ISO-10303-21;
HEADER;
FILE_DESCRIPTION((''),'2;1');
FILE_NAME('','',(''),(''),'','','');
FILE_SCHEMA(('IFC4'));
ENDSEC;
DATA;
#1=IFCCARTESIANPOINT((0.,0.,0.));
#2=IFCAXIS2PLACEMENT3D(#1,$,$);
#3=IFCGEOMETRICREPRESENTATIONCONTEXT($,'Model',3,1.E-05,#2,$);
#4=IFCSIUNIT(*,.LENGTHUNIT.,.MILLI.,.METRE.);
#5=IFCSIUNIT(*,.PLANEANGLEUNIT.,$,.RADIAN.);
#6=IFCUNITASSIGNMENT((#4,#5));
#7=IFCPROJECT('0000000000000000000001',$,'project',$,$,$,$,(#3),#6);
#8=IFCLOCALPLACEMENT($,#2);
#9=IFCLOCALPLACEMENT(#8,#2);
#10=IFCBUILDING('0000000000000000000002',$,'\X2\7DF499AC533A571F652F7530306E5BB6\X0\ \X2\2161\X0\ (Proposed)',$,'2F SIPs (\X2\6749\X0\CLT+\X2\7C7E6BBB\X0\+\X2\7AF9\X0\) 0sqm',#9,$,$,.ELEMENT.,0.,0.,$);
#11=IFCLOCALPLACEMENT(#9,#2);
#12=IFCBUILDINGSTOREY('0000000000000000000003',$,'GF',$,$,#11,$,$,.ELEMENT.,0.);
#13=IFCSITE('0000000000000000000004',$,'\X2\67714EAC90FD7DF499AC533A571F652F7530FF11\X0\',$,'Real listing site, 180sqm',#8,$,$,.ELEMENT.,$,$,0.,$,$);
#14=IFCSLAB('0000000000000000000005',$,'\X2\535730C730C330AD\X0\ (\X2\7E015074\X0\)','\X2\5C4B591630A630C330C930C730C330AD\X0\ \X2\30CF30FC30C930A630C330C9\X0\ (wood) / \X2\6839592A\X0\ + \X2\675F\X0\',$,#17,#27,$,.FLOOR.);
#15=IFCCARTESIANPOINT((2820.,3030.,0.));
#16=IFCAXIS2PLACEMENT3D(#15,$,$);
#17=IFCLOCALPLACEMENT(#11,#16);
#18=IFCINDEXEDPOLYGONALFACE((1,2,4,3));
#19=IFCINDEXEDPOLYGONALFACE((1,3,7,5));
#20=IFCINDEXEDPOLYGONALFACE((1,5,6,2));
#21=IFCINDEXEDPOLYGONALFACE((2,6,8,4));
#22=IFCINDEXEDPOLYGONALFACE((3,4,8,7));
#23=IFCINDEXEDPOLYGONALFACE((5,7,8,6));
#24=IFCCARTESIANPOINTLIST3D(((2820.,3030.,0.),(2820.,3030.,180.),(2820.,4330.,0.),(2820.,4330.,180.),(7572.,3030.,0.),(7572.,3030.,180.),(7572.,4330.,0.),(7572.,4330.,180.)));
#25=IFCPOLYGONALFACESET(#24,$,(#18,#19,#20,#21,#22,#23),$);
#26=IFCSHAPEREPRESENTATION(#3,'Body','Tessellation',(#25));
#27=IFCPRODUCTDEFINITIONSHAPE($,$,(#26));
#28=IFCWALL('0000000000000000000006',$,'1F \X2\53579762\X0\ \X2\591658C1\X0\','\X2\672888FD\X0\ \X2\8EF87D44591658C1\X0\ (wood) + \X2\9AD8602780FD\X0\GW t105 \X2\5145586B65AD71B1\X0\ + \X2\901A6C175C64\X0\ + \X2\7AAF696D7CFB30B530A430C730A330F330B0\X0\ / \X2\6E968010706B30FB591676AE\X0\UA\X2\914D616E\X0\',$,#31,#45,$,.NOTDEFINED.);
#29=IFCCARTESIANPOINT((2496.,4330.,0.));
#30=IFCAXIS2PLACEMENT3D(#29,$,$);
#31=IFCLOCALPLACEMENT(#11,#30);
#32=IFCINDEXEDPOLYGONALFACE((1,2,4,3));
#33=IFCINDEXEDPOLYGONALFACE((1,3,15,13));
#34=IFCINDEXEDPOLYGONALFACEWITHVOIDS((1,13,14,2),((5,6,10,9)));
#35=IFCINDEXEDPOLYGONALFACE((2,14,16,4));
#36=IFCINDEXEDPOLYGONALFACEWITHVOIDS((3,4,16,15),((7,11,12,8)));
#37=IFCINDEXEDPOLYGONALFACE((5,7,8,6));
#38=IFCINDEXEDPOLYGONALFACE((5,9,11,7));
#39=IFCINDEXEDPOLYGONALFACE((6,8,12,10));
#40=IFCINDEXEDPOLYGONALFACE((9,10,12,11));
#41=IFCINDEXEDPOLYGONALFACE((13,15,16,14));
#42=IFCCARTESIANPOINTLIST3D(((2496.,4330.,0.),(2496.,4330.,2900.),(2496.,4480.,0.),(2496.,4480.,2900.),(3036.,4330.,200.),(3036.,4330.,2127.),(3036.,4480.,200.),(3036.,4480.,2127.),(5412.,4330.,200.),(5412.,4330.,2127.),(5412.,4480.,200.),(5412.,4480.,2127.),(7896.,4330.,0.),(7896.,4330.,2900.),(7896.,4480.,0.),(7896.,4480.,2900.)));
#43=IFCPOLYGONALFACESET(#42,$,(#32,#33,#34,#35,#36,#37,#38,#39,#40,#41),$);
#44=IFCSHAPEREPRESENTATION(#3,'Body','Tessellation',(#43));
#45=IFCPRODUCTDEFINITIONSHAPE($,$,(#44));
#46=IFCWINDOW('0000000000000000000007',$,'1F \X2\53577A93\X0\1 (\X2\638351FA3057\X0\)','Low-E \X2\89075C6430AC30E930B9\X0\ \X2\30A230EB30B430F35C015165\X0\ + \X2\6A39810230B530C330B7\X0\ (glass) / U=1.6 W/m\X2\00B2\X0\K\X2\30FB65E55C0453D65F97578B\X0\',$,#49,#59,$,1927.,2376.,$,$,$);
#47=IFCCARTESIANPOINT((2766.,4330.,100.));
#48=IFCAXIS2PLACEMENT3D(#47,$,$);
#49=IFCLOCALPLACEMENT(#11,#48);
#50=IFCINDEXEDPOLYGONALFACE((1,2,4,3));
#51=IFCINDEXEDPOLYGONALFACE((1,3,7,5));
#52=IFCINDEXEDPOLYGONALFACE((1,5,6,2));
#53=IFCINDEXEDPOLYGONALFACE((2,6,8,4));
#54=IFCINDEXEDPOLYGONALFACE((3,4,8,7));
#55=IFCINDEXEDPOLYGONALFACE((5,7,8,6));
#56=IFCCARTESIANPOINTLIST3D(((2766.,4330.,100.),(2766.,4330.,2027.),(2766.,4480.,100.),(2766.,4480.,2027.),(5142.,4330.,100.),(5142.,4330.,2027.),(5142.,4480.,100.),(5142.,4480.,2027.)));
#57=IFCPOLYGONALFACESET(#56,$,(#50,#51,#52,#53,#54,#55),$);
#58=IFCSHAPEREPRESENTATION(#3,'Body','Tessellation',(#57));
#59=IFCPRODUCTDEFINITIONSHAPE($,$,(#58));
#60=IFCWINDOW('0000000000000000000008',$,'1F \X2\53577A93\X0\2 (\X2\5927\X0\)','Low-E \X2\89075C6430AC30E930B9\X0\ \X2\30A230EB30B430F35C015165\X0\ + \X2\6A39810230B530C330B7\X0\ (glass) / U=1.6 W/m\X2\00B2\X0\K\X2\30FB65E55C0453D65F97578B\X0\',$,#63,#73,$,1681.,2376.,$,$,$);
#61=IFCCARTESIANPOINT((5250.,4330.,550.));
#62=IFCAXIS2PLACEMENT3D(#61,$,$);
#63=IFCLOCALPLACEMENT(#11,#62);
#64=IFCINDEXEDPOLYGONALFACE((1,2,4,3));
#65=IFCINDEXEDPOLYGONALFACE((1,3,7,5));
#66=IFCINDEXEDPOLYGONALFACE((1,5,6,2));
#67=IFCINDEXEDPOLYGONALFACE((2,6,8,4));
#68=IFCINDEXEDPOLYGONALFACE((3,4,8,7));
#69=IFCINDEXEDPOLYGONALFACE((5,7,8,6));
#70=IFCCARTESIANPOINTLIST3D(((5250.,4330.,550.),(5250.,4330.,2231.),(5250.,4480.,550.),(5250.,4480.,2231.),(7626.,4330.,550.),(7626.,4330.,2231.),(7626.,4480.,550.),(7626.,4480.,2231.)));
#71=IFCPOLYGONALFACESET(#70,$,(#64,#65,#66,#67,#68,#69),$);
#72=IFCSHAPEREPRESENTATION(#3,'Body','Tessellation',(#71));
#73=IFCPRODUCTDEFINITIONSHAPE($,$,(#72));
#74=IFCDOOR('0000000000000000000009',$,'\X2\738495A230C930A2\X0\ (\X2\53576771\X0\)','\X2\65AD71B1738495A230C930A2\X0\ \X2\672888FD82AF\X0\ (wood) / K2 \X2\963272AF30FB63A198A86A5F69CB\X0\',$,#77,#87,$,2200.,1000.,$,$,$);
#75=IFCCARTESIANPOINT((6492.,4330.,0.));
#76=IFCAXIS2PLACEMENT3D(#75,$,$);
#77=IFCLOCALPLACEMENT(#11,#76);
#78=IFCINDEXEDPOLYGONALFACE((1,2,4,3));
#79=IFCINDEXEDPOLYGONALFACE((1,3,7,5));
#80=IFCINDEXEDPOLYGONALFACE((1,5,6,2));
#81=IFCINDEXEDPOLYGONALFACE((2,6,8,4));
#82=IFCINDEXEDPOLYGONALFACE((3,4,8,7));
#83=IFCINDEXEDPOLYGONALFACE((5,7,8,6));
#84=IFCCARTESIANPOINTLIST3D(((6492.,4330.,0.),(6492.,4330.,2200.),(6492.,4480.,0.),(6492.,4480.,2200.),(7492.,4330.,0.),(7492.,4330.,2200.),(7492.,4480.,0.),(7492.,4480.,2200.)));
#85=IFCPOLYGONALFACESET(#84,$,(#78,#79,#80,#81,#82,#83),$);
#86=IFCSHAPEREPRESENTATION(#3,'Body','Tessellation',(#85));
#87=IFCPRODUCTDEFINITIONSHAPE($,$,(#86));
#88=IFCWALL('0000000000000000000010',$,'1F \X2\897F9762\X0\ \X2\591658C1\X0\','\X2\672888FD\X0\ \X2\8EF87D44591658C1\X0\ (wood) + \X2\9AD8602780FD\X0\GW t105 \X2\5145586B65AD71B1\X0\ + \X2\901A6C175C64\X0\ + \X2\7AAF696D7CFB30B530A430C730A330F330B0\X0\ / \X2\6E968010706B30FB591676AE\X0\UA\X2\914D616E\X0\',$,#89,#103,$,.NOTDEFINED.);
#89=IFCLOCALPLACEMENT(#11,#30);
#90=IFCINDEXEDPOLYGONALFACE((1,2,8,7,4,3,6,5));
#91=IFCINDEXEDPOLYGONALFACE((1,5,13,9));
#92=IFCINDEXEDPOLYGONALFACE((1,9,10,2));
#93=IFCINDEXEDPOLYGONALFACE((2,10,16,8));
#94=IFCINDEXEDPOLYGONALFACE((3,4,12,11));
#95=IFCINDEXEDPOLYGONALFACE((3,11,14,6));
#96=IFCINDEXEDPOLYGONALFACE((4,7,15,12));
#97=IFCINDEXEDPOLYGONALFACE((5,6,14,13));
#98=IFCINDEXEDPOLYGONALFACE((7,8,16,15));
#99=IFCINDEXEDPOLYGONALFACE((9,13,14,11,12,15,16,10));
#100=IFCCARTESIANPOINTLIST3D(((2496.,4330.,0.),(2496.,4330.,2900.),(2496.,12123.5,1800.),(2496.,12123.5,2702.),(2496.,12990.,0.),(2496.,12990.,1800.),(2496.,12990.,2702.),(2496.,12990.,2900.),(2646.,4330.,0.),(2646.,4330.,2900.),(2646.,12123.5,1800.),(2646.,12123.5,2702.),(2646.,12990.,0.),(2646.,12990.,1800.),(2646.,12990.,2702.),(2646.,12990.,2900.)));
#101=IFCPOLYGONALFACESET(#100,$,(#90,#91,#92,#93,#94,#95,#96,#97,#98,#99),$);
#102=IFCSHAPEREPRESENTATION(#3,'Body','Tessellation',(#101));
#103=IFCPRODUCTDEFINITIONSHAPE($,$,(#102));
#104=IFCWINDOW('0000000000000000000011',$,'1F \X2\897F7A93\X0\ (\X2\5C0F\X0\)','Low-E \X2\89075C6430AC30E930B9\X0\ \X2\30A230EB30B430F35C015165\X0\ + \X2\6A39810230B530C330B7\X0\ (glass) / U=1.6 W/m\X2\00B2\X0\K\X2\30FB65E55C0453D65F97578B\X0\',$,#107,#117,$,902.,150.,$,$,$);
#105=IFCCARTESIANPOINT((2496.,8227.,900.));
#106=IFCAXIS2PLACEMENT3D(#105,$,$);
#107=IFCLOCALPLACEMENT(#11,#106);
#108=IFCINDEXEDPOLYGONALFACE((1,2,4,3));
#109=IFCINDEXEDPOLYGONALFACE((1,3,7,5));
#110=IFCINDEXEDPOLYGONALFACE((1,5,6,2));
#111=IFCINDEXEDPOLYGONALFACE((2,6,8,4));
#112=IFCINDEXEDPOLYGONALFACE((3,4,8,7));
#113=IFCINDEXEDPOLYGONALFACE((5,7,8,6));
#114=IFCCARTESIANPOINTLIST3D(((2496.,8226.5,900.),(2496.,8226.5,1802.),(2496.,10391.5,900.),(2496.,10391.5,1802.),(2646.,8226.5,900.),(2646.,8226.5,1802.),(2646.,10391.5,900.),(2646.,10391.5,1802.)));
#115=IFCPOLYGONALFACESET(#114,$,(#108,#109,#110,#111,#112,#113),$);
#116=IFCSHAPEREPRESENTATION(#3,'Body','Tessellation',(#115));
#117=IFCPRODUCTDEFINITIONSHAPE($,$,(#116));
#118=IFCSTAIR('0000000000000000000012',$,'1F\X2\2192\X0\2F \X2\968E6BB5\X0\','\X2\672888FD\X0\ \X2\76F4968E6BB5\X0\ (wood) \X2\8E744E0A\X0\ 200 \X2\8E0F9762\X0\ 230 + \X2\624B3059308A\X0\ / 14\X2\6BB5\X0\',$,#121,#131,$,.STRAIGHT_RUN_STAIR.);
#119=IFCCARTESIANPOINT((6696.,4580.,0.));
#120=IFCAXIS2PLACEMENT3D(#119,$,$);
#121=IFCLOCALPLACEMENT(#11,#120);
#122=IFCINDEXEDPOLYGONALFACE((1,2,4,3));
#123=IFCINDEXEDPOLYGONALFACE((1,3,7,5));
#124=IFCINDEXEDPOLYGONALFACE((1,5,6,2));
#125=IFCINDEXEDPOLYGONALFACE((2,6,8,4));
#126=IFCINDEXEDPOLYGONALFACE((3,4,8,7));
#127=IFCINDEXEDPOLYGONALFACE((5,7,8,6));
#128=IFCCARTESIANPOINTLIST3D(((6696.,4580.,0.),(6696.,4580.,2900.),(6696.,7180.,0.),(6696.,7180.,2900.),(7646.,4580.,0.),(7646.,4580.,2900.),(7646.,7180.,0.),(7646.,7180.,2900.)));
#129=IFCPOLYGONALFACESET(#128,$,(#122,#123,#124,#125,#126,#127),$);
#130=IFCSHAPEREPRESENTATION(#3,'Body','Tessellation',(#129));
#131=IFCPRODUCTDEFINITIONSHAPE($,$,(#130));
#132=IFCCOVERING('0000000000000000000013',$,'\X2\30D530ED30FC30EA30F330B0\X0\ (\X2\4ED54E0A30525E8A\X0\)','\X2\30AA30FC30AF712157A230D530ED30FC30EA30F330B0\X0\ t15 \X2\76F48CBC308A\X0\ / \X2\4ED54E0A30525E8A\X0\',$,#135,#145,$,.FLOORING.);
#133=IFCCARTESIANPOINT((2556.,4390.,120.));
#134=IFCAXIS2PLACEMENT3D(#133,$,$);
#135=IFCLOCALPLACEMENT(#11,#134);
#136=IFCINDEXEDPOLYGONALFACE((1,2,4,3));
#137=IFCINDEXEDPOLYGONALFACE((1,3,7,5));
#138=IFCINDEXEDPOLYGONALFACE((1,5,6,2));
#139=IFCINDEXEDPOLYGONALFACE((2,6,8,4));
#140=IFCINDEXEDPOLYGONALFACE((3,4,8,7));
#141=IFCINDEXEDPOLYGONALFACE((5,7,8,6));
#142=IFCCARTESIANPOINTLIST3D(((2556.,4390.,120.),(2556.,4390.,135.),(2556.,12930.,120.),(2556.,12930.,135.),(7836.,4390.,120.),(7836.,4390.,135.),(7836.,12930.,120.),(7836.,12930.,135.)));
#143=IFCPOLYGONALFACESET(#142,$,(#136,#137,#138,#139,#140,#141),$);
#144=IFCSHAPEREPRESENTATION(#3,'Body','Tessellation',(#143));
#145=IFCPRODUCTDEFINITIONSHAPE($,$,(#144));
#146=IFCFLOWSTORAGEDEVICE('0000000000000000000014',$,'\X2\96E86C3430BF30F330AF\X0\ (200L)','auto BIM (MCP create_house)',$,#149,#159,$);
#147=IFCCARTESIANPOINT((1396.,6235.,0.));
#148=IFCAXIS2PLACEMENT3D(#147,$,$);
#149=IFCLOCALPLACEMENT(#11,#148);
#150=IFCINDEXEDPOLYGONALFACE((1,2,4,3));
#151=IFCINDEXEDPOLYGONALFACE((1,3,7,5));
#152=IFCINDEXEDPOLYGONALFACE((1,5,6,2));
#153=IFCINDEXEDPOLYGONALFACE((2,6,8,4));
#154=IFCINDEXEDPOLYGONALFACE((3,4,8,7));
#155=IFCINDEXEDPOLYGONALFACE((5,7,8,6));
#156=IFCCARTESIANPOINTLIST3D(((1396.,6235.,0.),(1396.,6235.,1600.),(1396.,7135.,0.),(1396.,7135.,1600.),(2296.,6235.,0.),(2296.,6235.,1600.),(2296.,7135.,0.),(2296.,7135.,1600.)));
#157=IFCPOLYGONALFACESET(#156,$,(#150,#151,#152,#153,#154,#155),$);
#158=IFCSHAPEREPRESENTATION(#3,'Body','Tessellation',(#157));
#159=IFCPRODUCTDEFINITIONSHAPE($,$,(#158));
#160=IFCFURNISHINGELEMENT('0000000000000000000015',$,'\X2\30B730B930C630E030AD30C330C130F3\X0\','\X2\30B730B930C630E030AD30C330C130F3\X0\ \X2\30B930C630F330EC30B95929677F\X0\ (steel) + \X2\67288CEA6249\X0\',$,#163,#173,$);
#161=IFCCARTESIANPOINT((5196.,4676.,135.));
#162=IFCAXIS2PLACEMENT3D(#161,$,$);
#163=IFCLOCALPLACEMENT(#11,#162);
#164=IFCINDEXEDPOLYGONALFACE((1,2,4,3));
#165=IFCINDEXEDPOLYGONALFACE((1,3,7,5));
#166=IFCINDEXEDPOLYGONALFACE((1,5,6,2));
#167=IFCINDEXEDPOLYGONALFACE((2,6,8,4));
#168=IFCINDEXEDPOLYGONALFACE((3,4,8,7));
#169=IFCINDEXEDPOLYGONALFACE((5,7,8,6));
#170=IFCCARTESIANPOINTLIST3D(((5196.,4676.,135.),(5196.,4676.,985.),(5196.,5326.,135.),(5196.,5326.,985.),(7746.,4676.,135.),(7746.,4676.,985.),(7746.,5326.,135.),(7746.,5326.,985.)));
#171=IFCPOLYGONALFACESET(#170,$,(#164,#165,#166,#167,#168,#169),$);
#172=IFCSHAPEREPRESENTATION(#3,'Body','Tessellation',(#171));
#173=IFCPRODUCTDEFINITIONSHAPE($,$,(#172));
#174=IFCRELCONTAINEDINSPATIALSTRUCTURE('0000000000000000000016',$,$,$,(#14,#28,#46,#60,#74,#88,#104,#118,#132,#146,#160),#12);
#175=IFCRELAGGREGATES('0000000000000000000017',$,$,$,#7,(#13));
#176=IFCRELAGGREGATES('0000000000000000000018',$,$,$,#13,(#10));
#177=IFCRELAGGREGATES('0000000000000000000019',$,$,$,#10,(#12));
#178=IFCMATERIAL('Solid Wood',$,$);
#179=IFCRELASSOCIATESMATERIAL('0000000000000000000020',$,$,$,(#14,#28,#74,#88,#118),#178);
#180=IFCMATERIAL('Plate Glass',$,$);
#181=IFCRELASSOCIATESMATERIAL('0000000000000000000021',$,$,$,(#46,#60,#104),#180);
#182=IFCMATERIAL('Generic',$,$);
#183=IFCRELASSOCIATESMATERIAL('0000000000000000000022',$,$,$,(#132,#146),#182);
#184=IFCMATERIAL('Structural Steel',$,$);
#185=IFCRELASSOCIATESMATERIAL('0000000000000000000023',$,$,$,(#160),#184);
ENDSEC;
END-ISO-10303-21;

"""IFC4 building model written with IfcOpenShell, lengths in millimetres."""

from ifc_helpers import new_model, si_unit, frame, frame_2d, origin, place, context, project, spatial, rectangle, extrude, material, element, fill, save


model = new_model("IFC4")

# Units and contexts
model_context = context("Model", 3, precision=1e-05, world=origin())
ifc_project = project(units=[si_unit("LENGTHUNIT", "METRE", prefix="MILLI"), si_unit("PLANEANGLEUNIT", "RADIAN")], contexts=[model_context])

# Site, building, storey
site_placement = place(None, origin())
site = spatial("IfcSite", under=ifc_project, at=site_placement, Name="東京都練馬区土支田１", ObjectType="Real listing site, 180sqm", CompositionType="ELEMENT", RefElevation=0.0)
building_placement = place(site_placement, origin())
building = spatial("IfcBuilding", under=site, at=building_placement, Name="練馬区土支田の家 Ⅱ (Proposed)", ObjectType="2F SIPs (杉CLT+籾殻+竹) 0sqm", CompositionType="ELEMENT", ElevationOfRefHeight=0.0, ElevationOfTerrain=0.0)
storey_placement = place(building_placement, origin())
storey = spatial("IfcBuildingStorey", under=building, at=storey_placement, Name="GF", CompositionType="ELEMENT", Elevation=0.0)

# Slab
ifc_material_1 = material(Name="Solid Wood")
slab_1_placement = place(storey_placement, frame((2820.0, 3030.0, 0.0)))
element("IfcSlab", 1, at=slab_1_placement, inside=storey, material=ifc_material_1, Name="南デッキ (縁側)", Description="屋外ウッドデッキ ハードウッド (wood) / 根太 + 束", PredefinedType="FLOOR", context=model_context, shape_type="SweptSolid", body=[
    extrude(rectangle(XDim=4752.0, YDim=1300.0, at=frame_2d((2376.0, 650.0))), frame((2820.0, 3030.0, 0.0)), (0.0, 0.0, 1.0), 180.0),
])

# Wall, openings, windows, door
wall_1_placement = place(storey_placement, frame((2496.0, 4330.0, 0.0)))
wall_1 = element("IfcWall", 2, at=wall_1_placement, inside=storey, material=ifc_material_1, Name="1F 南面 外壁", Description="木製 軸組外壁 (wood) + 高性能GW t105 充填断熱 + 通気層 + 窯業系サイディング / 準耐火・外皮UA配慮", PredefinedType="NOTDEFINED", context=model_context, shape_type="SweptSolid", body=[
    extrude(rectangle(XDim=5400.0, YDim=150.0, at=frame_2d((2700.0, 75.0))), frame((2496.0, 4330.0, 0.0)), (0.0, 0.0, 1.0), 2900.0),
])
opening_1_placement = place(storey_placement, frame((2766.0, 4330.0, 100.0)))
opening_1 = element("IfcOpeningElement", 3, at=opening_1_placement, cuts=wall_1, PredefinedType="NOTDEFINED", context=model_context, shape_type="SweptSolid", body=[
    extrude(rectangle(XDim=2376.0, YDim=150.0, at=frame_2d((1188.0, 75.0))), frame((2766.0, 4330.0, 100.0)), (0.0, 0.0, 1.0), 1927.0),
])
opening_2_placement = place(storey_placement, frame((5250.0, 4330.0, 550.0)))
opening_2 = element("IfcOpeningElement", 4, at=opening_2_placement, cuts=wall_1, PredefinedType="NOTDEFINED", context=model_context, shape_type="SweptSolid", body=[
    extrude(rectangle(XDim=2376.0, YDim=150.0, at=frame_2d((1188.0, 75.0))), frame((5250.0, 4330.0, 550.0)), (0.0, 0.0, 1.0), 1681.0),
])
opening_3_placement = place(storey_placement, frame((6492.0, 4330.0, 0.0)))
opening_3 = element("IfcOpeningElement", 5, at=opening_3_placement, cuts=wall_1, PredefinedType="NOTDEFINED", context=model_context, shape_type="SweptSolid", body=[
    extrude(rectangle(XDim=1000.0, YDim=150.0, at=frame_2d((500.0, 75.0))), frame((6492.0, 4330.0, 0.0)), (0.0, 0.0, 1.0), 2200.0),
])
ifc_material_2 = material(Name="Plate Glass")
window_1_placement = place(storey_placement, frame((2766.0, 4330.0, 100.0)))
window_1 = element("IfcWindow", 6, at=window_1_placement, inside=storey, material=ifc_material_2, Name="1F 南窓1 (掃出し)", Description="Low-E 複層ガラス アルゴン封入 + 樹脂サッシ (glass) / U=1.6 W/m²K・日射取得型", OverallHeight=1927.0, OverallWidth=2376.0, context=model_context, shape_type="SweptSolid", body=[
    extrude(rectangle(XDim=2376.0, YDim=150.0, at=frame_2d((1188.0, 75.0))), frame((2766.0, 4330.0, 100.0)), (0.0, 0.0, 1.0), 1927.0),
])
fill(opening_1, window_1)
window_2_placement = place(storey_placement, frame((5250.0, 4330.0, 550.0)))
window_2 = element("IfcWindow", 7, at=window_2_placement, inside=storey, material=ifc_material_2, Name="1F 南窓2 (大)", Description="Low-E 複層ガラス アルゴン封入 + 樹脂サッシ (glass) / U=1.6 W/m²K・日射取得型", OverallHeight=1681.0, OverallWidth=2376.0, context=model_context, shape_type="SweptSolid", body=[
    extrude(rectangle(XDim=2376.0, YDim=150.0, at=frame_2d((1188.0, 75.0))), frame((5250.0, 4330.0, 550.0)), (0.0, 0.0, 1.0), 1681.0),
])
fill(opening_2, window_2)
door_placement = place(storey_placement, frame((6492.0, 4330.0, 0.0)))
door = element("IfcDoor", 8, at=door_placement, inside=storey, material=ifc_material_1, Name="玄関ドア (南東)", Description="断熱玄関ドア 木製芯 (wood) / K2 防犯・採風機構", OverallHeight=2200.0, OverallWidth=1000.0, context=model_context, shape_type="SweptSolid", body=[
    extrude(rectangle(XDim=1000.0, YDim=150.0, at=frame_2d((500.0, 75.0))), frame((6492.0, 4330.0, 0.0)), (0.0, 0.0, 1.0), 2200.0),
])
fill(opening_3, door)

# Wall, opening, window
wall_2_placement = place(storey_placement, frame((2496.0, 4330.0, 0.0)))
wall_2 = element("IfcWall", 9, at=wall_2_placement, inside=storey, material=ifc_material_1, Name="1F 西面 外壁", Description="木製 軸組外壁 (wood) + 高性能GW t105 充填断熱 + 通気層 + 窯業系サイディング / 準耐火・外皮UA配慮", PredefinedType="NOTDEFINED", context=model_context, shape_type="SweptSolid", body=[
    extrude(rectangle(XDim=150.0, YDim=8660.0, at=frame_2d((75.0, 4330.0))), frame((2496.0, 4330.0, 0.0)), (0.0, 0.0, 1.0), 2900.0),
])
opening_4_placement = place(storey_placement, frame((2496.0, 8227.0, 900.0)))
opening_4 = element("IfcOpeningElement", 10, at=opening_4_placement, cuts=wall_2, PredefinedType="NOTDEFINED", context=model_context, shape_type="SweptSolid", body=[
    extrude(rectangle(XDim=150.0, YDim=2165.0, at=frame_2d((75.0, 1082.0))), frame((2496.0, 8227.0, 900.0)), (0.0, 0.0, 1.0), 902.0),
])
window_3_placement = place(storey_placement, frame((2496.0, 8227.0, 900.0)))
window_3 = element("IfcWindow", 11, at=window_3_placement, inside=storey, material=ifc_material_2, Name="1F 西窓 (小)", Description="Low-E 複層ガラス アルゴン封入 + 樹脂サッシ (glass) / U=1.6 W/m²K・日射取得型", OverallHeight=902.0, OverallWidth=150.0, context=model_context, shape_type="SweptSolid", body=[
    extrude(rectangle(XDim=150.0, YDim=2165.0, at=frame_2d((75.0, 1082.0))), frame((2496.0, 8227.0, 900.0)), (0.0, 0.0, 1.0), 902.0),
])
fill(opening_4, window_3)

# Stair
stair_placement = place(storey_placement, frame((6696.0, 4580.0, 0.0)))
element("IfcStair", 12, at=stair_placement, inside=storey, material=ifc_material_1, Name="1F→2F 階段", Description="木製 直階段 (wood) 蹴上 200 踏面 230 + 手すり / 14段", PredefinedType="STRAIGHT_RUN_STAIR", context=model_context, shape_type="SweptSolid", body=[
    extrude(rectangle(XDim=950.0, YDim=2600.0, at=frame_2d((475.0, 1300.0))), frame((6696.0, 4580.0, 0.0)), (0.0, 0.0, 1.0), 2900.0),
])

# Covering
ifc_material_3 = material(Name="Generic")
covering_placement = place(storey_placement, frame((2556.0, 4390.0, 120.0)))
element("IfcCovering", 13, at=covering_placement, inside=storey, material=ifc_material_3, Name="フローリング (仕上げ床)", Description="オーク無垢フローリング t15 直貼り / 仕上げ床", PredefinedType="FLOORING", context=model_context, shape_type="SweptSolid", body=[
    extrude(rectangle(XDim=5280.0, YDim=8540.0, at=frame_2d((2640.0, 4270.0))), frame((2556.0, 4390.0, 120.0)), (0.0, 0.0, 1.0), 15.0),
])

# Flow storage device
flow_storage_device_placement = place(storey_placement, frame((1396.0, 6235.0, 0.0)))
element("IfcFlowStorageDevice", 14, at=flow_storage_device_placement, inside=storey, material=ifc_material_3, Name="雨水タンク (200L)", Description="auto BIM (MCP create_house)", context=model_context, shape_type="SweptSolid", body=[
    extrude(rectangle(XDim=900.0, YDim=900.0, at=frame_2d((450.0, 450.0))), frame((1396.0, 6235.0, 0.0)), (0.0, 0.0, 1.0), 1600.0),
])

# Furnishing element
ifc_material_4 = material(Name="Structural Steel")
furnishing_placement = place(storey_placement, frame((5196.0, 4676.0, 135.0)))
element("IfcFurnishingElement", 15, at=furnishing_placement, inside=storey, material=ifc_material_4, Name="システムキッチン", Description="システムキッチン ステンレス天板 (steel) + 木質扉", context=model_context, shape_type="SweptSolid", body=[
    extrude(rectangle(XDim=2550.0, YDim=650.0, at=frame_2d((1275.0, 325.0))), frame((5196.0, 4676.0, 135.0)), (0.0, 0.0, 1.0), 850.0),
])

save(model, "model.ifc")
